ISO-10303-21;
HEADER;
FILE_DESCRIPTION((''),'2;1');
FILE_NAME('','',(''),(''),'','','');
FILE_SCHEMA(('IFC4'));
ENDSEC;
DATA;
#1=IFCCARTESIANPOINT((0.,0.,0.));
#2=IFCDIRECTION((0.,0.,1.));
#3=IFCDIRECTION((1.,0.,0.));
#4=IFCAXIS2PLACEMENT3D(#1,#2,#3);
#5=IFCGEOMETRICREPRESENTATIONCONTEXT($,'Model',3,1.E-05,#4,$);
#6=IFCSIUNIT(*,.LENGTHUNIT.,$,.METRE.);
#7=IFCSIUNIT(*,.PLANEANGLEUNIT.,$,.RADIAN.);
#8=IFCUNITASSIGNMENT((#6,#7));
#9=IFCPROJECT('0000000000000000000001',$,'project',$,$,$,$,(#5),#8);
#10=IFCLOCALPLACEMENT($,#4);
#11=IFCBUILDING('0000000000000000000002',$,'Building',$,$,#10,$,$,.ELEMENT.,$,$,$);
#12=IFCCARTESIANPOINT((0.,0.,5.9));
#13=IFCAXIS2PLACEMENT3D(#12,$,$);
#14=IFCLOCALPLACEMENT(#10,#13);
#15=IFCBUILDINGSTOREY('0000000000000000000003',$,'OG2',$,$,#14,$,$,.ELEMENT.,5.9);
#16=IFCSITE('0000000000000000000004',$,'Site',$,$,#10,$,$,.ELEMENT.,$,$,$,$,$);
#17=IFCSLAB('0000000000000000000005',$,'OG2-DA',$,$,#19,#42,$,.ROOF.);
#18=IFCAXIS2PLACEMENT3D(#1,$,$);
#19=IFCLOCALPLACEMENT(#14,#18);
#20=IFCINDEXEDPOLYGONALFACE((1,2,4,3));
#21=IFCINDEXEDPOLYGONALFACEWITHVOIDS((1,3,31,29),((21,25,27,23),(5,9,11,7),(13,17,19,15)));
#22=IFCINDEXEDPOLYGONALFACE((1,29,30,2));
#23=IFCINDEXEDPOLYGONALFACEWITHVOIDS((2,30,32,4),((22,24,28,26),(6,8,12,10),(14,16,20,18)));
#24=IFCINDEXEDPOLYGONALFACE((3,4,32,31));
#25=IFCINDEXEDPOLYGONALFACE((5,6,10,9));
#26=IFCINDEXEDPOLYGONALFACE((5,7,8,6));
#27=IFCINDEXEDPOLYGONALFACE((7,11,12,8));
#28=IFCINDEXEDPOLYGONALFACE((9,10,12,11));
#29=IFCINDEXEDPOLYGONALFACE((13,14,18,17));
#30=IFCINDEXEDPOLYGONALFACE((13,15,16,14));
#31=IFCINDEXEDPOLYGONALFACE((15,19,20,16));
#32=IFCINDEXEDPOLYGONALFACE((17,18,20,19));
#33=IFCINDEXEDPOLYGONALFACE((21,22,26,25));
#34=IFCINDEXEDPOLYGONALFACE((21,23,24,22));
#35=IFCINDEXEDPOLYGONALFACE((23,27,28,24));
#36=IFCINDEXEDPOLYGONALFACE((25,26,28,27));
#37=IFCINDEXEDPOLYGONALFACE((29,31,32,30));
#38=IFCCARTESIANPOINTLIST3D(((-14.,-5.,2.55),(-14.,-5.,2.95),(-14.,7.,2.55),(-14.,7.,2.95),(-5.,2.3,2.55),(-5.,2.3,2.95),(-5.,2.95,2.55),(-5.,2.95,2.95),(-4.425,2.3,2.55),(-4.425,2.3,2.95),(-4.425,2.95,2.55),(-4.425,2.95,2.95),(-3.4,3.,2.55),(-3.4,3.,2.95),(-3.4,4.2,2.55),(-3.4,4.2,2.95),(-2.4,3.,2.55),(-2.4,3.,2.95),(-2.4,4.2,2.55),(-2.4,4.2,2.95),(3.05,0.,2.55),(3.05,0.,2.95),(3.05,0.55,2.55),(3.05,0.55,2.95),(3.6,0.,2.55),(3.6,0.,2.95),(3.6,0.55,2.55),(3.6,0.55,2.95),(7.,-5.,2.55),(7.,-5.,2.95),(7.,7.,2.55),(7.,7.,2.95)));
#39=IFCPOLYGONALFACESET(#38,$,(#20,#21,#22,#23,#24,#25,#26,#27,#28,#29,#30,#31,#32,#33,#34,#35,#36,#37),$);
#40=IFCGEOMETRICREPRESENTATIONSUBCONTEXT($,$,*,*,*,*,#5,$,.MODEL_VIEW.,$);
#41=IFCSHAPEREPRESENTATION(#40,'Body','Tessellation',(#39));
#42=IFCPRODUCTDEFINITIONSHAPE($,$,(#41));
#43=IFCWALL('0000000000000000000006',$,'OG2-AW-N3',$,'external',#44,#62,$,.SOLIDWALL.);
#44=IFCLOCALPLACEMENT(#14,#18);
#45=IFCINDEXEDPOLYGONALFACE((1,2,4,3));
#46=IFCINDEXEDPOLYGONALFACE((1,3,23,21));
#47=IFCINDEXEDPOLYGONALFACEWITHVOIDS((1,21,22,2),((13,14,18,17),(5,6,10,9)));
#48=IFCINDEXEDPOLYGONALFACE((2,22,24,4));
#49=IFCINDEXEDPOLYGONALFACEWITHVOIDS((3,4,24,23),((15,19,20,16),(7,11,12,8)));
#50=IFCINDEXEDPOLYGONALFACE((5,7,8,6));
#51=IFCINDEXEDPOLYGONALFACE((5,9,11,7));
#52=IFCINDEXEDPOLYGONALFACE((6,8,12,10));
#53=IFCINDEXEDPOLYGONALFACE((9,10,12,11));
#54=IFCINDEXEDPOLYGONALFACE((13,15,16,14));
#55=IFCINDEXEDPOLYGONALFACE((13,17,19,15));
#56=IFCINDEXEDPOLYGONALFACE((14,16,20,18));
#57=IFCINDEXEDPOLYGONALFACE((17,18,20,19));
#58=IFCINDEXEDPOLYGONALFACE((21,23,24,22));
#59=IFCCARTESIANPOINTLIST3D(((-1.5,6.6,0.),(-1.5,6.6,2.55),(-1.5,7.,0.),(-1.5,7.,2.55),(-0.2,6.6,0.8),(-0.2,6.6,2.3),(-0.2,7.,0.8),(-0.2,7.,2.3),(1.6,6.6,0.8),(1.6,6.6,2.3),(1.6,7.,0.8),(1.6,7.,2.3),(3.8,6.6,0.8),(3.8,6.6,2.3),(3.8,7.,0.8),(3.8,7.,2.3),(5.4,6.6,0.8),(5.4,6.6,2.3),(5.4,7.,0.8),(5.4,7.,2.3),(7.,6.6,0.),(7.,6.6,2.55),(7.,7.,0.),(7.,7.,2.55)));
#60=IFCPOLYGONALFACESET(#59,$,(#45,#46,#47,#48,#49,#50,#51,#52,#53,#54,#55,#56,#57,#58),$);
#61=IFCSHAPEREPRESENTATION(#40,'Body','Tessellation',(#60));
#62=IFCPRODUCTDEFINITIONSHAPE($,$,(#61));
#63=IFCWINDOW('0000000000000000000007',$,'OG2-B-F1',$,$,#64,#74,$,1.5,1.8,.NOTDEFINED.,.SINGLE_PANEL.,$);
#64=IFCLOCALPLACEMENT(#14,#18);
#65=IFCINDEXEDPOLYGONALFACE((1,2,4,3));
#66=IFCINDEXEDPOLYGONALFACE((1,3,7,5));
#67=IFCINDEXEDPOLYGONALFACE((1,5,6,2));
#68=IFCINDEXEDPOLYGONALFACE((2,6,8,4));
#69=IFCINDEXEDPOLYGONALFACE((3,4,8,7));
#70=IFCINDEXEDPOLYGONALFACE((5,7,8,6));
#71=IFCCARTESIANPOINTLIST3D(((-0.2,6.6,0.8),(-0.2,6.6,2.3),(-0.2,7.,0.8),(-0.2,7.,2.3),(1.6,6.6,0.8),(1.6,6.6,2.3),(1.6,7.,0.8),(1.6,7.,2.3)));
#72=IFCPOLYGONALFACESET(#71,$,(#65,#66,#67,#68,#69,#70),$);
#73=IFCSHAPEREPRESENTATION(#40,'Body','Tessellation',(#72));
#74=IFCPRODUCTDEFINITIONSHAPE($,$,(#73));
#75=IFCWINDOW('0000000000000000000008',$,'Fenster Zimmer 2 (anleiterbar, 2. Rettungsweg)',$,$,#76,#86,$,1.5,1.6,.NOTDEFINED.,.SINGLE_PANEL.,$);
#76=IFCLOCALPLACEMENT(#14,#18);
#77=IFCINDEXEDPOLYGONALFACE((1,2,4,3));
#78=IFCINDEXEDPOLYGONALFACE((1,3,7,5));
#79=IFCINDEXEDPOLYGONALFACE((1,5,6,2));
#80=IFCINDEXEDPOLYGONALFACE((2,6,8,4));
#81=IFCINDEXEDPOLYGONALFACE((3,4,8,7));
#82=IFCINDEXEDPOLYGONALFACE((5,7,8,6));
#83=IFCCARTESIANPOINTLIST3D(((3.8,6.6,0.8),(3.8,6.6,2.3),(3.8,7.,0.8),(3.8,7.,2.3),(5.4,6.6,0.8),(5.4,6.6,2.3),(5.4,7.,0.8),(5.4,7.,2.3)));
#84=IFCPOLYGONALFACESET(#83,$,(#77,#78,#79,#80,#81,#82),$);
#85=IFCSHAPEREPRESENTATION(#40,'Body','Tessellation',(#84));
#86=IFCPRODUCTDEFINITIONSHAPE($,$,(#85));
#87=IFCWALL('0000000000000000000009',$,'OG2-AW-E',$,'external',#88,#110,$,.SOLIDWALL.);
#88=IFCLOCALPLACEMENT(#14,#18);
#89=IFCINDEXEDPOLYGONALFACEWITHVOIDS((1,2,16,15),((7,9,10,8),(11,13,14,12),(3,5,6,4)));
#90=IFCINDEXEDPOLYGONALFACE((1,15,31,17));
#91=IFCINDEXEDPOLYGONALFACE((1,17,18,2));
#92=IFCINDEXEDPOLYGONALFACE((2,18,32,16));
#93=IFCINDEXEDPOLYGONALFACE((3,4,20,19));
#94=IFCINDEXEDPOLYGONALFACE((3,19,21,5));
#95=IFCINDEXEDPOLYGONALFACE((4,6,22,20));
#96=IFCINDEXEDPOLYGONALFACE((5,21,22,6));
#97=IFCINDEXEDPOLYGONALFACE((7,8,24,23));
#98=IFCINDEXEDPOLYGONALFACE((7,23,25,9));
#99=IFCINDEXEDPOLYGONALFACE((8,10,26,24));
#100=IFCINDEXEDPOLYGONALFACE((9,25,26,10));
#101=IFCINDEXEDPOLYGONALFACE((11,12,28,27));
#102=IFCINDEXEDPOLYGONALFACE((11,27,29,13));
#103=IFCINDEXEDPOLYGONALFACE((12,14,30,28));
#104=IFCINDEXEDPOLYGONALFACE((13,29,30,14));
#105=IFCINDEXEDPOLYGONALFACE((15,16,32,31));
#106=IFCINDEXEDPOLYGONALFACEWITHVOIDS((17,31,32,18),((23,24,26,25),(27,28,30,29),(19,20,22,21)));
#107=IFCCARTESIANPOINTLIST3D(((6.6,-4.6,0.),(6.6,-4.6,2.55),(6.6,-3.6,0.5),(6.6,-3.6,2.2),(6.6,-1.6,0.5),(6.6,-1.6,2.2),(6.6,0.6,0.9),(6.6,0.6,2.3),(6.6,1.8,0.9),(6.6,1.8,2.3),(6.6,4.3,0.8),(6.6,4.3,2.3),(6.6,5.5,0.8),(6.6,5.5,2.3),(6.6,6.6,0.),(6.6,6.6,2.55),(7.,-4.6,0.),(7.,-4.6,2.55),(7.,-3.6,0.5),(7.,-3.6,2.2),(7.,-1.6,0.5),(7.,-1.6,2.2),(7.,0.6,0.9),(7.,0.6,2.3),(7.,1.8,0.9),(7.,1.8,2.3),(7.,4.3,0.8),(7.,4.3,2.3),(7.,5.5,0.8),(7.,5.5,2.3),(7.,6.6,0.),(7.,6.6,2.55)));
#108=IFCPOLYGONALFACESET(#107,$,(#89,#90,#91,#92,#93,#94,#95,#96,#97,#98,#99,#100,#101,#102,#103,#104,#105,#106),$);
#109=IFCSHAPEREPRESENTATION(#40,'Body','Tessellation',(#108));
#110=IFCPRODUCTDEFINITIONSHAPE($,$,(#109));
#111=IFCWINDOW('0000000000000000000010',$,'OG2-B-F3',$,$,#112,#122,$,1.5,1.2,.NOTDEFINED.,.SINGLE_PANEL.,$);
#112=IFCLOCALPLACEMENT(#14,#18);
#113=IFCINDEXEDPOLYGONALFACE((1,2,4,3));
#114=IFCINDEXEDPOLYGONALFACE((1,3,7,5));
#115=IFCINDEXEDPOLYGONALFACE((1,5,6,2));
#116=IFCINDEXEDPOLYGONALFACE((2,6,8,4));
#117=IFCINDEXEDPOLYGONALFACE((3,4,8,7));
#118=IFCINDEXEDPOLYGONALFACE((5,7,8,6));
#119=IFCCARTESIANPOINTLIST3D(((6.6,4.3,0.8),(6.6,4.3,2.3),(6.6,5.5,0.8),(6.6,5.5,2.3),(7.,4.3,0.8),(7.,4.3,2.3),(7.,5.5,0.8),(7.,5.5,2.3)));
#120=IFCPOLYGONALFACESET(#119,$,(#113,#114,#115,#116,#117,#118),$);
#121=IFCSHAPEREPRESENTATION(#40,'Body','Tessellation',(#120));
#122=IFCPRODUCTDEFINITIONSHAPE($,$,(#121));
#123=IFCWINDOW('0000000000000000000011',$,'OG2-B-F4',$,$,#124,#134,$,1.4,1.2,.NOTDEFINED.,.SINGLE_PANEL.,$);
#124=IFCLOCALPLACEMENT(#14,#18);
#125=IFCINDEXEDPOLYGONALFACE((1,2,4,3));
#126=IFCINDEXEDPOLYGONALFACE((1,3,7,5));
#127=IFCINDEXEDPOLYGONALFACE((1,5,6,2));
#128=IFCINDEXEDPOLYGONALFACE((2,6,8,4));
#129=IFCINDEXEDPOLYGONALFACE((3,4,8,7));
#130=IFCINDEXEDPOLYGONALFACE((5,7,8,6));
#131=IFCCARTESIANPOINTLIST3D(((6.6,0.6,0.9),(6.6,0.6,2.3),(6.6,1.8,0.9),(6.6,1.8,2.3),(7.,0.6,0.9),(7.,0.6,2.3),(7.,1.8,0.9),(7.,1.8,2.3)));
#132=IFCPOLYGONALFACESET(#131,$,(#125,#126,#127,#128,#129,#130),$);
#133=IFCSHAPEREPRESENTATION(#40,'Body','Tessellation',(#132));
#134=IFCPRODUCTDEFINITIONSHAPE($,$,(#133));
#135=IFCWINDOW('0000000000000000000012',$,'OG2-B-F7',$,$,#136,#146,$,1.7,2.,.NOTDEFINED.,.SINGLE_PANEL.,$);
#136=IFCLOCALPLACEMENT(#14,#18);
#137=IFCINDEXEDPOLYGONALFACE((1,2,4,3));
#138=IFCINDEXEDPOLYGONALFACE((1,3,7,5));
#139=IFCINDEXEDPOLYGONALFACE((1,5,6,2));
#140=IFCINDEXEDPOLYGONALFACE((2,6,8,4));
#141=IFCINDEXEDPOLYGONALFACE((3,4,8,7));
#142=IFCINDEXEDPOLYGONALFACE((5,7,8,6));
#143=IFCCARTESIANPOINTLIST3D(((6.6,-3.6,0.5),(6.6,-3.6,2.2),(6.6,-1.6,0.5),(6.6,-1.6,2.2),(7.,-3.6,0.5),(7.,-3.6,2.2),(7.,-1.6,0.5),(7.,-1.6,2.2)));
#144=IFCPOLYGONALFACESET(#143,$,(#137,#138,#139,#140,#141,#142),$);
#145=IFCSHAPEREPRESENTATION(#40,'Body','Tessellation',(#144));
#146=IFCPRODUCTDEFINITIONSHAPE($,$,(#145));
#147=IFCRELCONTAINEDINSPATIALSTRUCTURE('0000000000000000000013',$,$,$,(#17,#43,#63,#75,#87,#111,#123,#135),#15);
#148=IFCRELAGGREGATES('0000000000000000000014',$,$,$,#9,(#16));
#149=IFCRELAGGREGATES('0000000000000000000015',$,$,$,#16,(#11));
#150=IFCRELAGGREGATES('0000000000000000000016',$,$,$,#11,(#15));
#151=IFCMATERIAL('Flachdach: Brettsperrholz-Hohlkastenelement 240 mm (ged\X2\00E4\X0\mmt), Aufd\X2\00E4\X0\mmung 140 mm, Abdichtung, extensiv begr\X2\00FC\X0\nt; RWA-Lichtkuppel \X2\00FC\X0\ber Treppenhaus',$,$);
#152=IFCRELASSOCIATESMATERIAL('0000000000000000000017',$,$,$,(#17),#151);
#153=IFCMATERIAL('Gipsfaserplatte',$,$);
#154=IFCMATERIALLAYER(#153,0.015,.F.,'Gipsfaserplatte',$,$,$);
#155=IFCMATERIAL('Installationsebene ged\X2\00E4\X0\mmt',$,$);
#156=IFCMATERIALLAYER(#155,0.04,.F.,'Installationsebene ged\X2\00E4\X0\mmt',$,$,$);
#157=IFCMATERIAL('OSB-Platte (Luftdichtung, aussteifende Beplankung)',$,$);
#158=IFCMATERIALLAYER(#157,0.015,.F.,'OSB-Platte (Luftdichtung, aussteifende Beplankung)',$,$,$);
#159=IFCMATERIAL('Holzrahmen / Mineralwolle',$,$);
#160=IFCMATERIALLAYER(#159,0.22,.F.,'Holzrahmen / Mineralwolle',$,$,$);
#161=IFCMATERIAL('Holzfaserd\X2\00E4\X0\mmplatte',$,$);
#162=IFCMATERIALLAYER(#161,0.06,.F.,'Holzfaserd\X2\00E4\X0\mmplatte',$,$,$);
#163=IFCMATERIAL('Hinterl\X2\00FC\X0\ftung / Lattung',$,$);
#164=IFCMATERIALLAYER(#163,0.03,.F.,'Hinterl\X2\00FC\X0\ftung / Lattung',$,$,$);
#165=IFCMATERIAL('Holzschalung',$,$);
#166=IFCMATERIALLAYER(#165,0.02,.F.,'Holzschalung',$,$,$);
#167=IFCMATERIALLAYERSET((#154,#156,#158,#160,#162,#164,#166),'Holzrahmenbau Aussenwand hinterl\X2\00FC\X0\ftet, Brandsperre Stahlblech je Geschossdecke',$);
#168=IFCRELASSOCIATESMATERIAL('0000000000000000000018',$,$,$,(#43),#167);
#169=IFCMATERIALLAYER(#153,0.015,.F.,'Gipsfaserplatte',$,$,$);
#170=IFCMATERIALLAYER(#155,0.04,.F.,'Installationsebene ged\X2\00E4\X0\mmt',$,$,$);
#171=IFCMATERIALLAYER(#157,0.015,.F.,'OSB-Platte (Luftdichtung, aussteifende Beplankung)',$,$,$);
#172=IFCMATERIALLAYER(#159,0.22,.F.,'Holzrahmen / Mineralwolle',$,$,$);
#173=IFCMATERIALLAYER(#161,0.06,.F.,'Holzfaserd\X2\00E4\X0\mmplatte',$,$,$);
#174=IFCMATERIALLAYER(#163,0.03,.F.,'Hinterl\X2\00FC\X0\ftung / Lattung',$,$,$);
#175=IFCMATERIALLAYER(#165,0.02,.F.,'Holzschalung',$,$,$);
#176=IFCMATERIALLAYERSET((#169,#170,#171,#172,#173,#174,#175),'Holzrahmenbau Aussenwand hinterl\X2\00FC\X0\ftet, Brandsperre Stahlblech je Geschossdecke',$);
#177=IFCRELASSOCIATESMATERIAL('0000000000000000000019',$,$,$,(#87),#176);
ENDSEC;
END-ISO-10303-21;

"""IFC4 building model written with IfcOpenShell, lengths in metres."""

from ifc_helpers import new_model, si_unit, frame, frame_2d, origin, origin_with_axes, origin_2d, place, context, subcontext, project, spatial, polyline, rectangle, outline, extrude, material, layer, layer_set, element, fill, save


model = new_model("IFC4")

# Units and contexts
model_context = context("Model", 3, precision=1e-05, world=origin_with_axes())
sub_context = subcontext(model_context, None, None, "MODEL_VIEW")
ifc_project = project(units=[si_unit("LENGTHUNIT", "METRE"), si_unit("PLANEANGLEUNIT", "RADIAN")], contexts=[model_context])

# Site, building, storey
placement = place(None, origin_with_axes())
site = spatial("IfcSite", under=ifc_project, at=placement, Name="Site", CompositionType="ELEMENT")
building = spatial("IfcBuilding", under=site, at=placement, Name="Building", CompositionType="ELEMENT")
storey_placement = place(placement, frame((0.0, 0.0, 5.9)))
storey = spatial("IfcBuildingStorey", under=building, at=storey_placement, Name="OG2", CompositionType="ELEMENT", Elevation=5.9)

# Slab, openings
ifc_material_1 = material(Name="Flachdach: Brettsperrholz-Hohlkastenelement 240 mm (gedämmt), Aufdämmung 140 mm, Abdichtung, extensiv begrünt; RWA-Lichtkuppel über Treppenhaus")
slab_placement = place(storey_placement, frame((0.0, 0.0, 2.55)))
slab = element("IfcSlab", 1, at=slab_placement, inside=storey, material=ifc_material_1, Name="OG2-DA", PredefinedType="ROOF", context=sub_context, shape_type="SweptSolid", body=[
    extrude(outline(polyline([(-14.0, -5.0), (7.0, -5.0), (7.0, 7.0), (-14.0, 7.0), (-14.0, -5.0)])), origin(), (0.0, 0.0, 1.0), 0.4),
])
opening_1_placement = place(slab_placement, frame((-2.9, 3.6, 0.0)))
element("IfcOpeningElement", 2, at=opening_1_placement, cuts=slab, PredefinedType="OPENING", context=sub_context, shape_type="SweptSolid", body=[
    extrude(rectangle(XDim=1.0, YDim=1.2, at=origin_2d()), origin(), (0.0, 0.0, 1.0), 0.5),
])
opening_2_placement = place(slab_placement, frame((-4.7125, 2.625, 0.0)))
element("IfcOpeningElement", 3, at=opening_2_placement, cuts=slab, PredefinedType="OPENING", context=sub_context, shape_type="SweptSolid", body=[
    extrude(rectangle(XDim=0.575, YDim=0.65, at=origin_2d()), origin(), (0.0, 0.0, 1.0), 0.5),
])
opening_3_placement = place(slab_placement, frame((3.325, 0.275, 0.0)))
element("IfcOpeningElement", 4, at=opening_3_placement, cuts=slab, PredefinedType="OPENING", context=sub_context, shape_type="SweptSolid", body=[
    extrude(rectangle(XDim=0.55, YDim=0.55, at=origin_2d()), origin(), (0.0, 0.0, 1.0), 0.5),
])

# Walls, openings, windows
ifc_material_2 = material(Name="Gipsfaserplatte")
ifc_layer_1 = layer(ifc_material_2, 0.015, ventilated=False, Name="Gipsfaserplatte")
ifc_material_3 = material(Name="Installationsebene gedämmt")
ifc_layer_2 = layer(ifc_material_3, 0.04, ventilated=False, Name="Installationsebene gedämmt")
ifc_material_4 = material(Name="OSB-Platte (Luftdichtung, aussteifende Beplankung)")
ifc_layer_3 = layer(ifc_material_4, 0.015, ventilated=False, Name="OSB-Platte (Luftdichtung, aussteifende Beplankung)")
ifc_material_5 = material(Name="Holzrahmen / Mineralwolle")
ifc_layer_4 = layer(ifc_material_5, 0.22, ventilated=False, Name="Holzrahmen / Mineralwolle")
ifc_material_6 = material(Name="Holzfaserdämmplatte")
ifc_layer_5 = layer(ifc_material_6, 0.06, ventilated=False, Name="Holzfaserdämmplatte")
ifc_material_7 = material(Name="Hinterlüftung / Lattung")
ifc_layer_6 = layer(ifc_material_7, 0.03, ventilated=False, Name="Hinterlüftung / Lattung")
ifc_material_8 = material(Name="Holzschalung")
ifc_layer_7 = layer(ifc_material_8, 0.02, ventilated=False, Name="Holzschalung")
ifc_layer_set_1 = layer_set([ifc_layer_1, ifc_layer_2, ifc_layer_3, ifc_layer_4, ifc_layer_5, ifc_layer_6, ifc_layer_7], Name="Holzrahmenbau Aussenwand hinterlüftet, Brandsperre Stahlblech je Geschossdecke")
wall_1_placement = place(storey_placement, frame((-1.5, 6.8, 0.0), z_axis=(0.0, 0.0, 1.0), x_axis=(1.0, 0.0, 0.0)))
wall_1 = element("IfcWall", 5, at=wall_1_placement, inside=storey, material=ifc_layer_set_1, Name="OG2-AW-N3", ObjectType="external", PredefinedType="SOLIDWALL", context=sub_context, shape_type="SweptSolid", body=[
    extrude(rectangle(XDim=8.5, YDim=0.4, at=frame_2d((4.25, 0.0))), origin(), (0.0, 0.0, 1.0), 2.55),
])
opening_4_placement = place(wall_1_placement, frame((2.2, 0.25, 0.8), z_axis=(0.0, -1.0, 0.0), x_axis=(1.0, 0.0, 0.0)))
opening_4 = element("IfcOpeningElement", 6, at=opening_4_placement, cuts=wall_1, PredefinedType="OPENING", context=sub_context, shape_type="SweptSolid", body=[
    extrude(rectangle(XDim=1.8, YDim=1.5, at=frame_2d((0.0, 0.75))), origin(), (0.0, 0.0, 1.0), 0.5),
])
opening_5_placement = place(wall_1_placement, frame((6.1, 0.25, 0.8), z_axis=(0.0, -1.0, 0.0), x_axis=(1.0, 0.0, 0.0)))
opening_5 = element("IfcOpeningElement", 7, at=opening_5_placement, cuts=wall_1, PredefinedType="OPENING", context=sub_context, shape_type="SweptSolid", body=[
    extrude(rectangle(XDim=1.6, YDim=1.5, at=frame_2d((0.0, 0.75))), origin(), (0.0, 0.0, 1.0), 0.5),
])
window_1_placement = place(wall_1_placement, frame((2.2, 0.2, 0.8), z_axis=(0.0, -1.0, 0.0), x_axis=(1.0, 0.0, 0.0)))
window_1 = element("IfcWindow", 8, at=window_1_placement, inside=storey, Name="OG2-B-F1", OverallHeight=1.5, OverallWidth=1.8, PartitioningType="SINGLE_PANEL", PredefinedType="NOTDEFINED", context=sub_context, shape_type="SweptSolid", body=[
    extrude(rectangle(XDim=1.8, YDim=1.5, at=frame_2d((0.0, 0.75))), origin(), (0.0, 0.0, 1.0), 0.4),
])
fill(opening_4, window_1)
window_2_placement = place(wall_1_placement, frame((6.1, 0.2, 0.8), z_axis=(0.0, -1.0, 0.0), x_axis=(1.0, 0.0, 0.0)))
window_2 = element("IfcWindow", 9, at=window_2_placement, inside=storey, Name="Fenster Zimmer 2 (anleiterbar, 2. Rettungsweg)", OverallHeight=1.5, OverallWidth=1.6, PartitioningType="SINGLE_PANEL", PredefinedType="NOTDEFINED", context=sub_context, shape_type="SweptSolid", body=[
    extrude(rectangle(XDim=1.6, YDim=1.5, at=frame_2d((0.0, 0.75))), origin(), (0.0, 0.0, 1.0), 0.4),
])
fill(opening_5, window_2)
ifc_layer_8 = layer(ifc_material_2, 0.015, ventilated=False, Name="Gipsfaserplatte")
ifc_layer_9 = layer(ifc_material_3, 0.04, ventilated=False, Name="Installationsebene gedämmt")
ifc_layer_10 = layer(ifc_material_4, 0.015, ventilated=False, Name="OSB-Platte (Luftdichtung, aussteifende Beplankung)")
ifc_layer_11 = layer(ifc_material_5, 0.22, ventilated=False, Name="Holzrahmen / Mineralwolle")
ifc_layer_12 = layer(ifc_material_6, 0.06, ventilated=False, Name="Holzfaserdämmplatte")
ifc_layer_13 = layer(ifc_material_7, 0.03, ventilated=False, Name="Hinterlüftung / Lattung")
ifc_layer_14 = layer(ifc_material_8, 0.02, ventilated=False, Name="Holzschalung")
ifc_layer_set_2 = layer_set([ifc_layer_8, ifc_layer_9, ifc_layer_10, ifc_layer_11, ifc_layer_12, ifc_layer_13, ifc_layer_14], Name="Holzrahmenbau Aussenwand hinterlüftet, Brandsperre Stahlblech je Geschossdecke")
wall_2_placement = place(storey_placement, frame((6.8, 6.6, 0.0), z_axis=(0.0, 0.0, 1.0), x_axis=(0.0, -1.0, 0.0)))
wall_2 = element("IfcWall", 10, at=wall_2_placement, inside=storey, material=ifc_layer_set_2, Name="OG2-AW-E", ObjectType="external", PredefinedType="SOLIDWALL", context=sub_context, shape_type="SweptSolid", body=[
    extrude(rectangle(XDim=11.2, YDim=0.4, at=frame_2d((5.6, 0.0))), origin(), (0.0, 0.0, 1.0), 2.55),
])
opening_6_placement = place(wall_2_placement, frame((1.7, 0.25, 0.8), z_axis=(0.0, -1.0, 0.0), x_axis=(1.0, 0.0, 0.0)))
opening_6 = element("IfcOpeningElement", 11, at=opening_6_placement, cuts=wall_2, PredefinedType="OPENING", context=sub_context, shape_type="SweptSolid", body=[
    extrude(rectangle(XDim=1.2, YDim=1.5, at=frame_2d((0.0, 0.75))), origin(), (0.0, 0.0, 1.0), 0.5),
])
opening_7_placement = place(wall_2_placement, frame((5.4, 0.25, 0.9), z_axis=(0.0, -1.0, 0.0), x_axis=(1.0, 0.0, 0.0)))
opening_7 = element("IfcOpeningElement", 12, at=opening_7_placement, cuts=wall_2, PredefinedType="OPENING", context=sub_context, shape_type="SweptSolid", body=[
    extrude(rectangle(XDim=1.2, YDim=1.4, at=frame_2d((0.0, 0.7))), origin(), (0.0, 0.0, 1.0), 0.5),
])
opening_8_placement = place(wall_2_placement, frame((9.2, 0.25, 0.5), z_axis=(0.0, -1.0, 0.0), x_axis=(1.0, 0.0, 0.0)))
opening_8 = element("IfcOpeningElement", 13, at=opening_8_placement, cuts=wall_2, PredefinedType="OPENING", context=sub_context, shape_type="SweptSolid", body=[
    extrude(rectangle(XDim=2.0, YDim=1.7, at=frame_2d((0.0, 0.85))), origin(), (0.0, 0.0, 1.0), 0.5),
])
window_3_placement = place(wall_2_placement, frame((1.7, 0.2, 0.8), z_axis=(0.0, -1.0, 0.0), x_axis=(1.0, 0.0, 0.0)))
window_3 = element("IfcWindow", 14, at=window_3_placement, inside=storey, Name="OG2-B-F3", OverallHeight=1.5, OverallWidth=1.2, PartitioningType="SINGLE_PANEL", PredefinedType="NOTDEFINED", context=sub_context, shape_type="SweptSolid", body=[
    extrude(rectangle(XDim=1.2, YDim=1.5, at=frame_2d((0.0, 0.75))), origin(), (0.0, 0.0, 1.0), 0.4),
])
fill(opening_6, window_3)
window_4_placement = place(wall_2_placement, frame((5.4, 0.2, 0.9), z_axis=(0.0, -1.0, 0.0), x_axis=(1.0, 0.0, 0.0)))
window_4 = element("IfcWindow", 15, at=window_4_placement, inside=storey, Name="OG2-B-F4", OverallHeight=1.4, OverallWidth=1.2, PartitioningType="SINGLE_PANEL", PredefinedType="NOTDEFINED", context=sub_context, shape_type="SweptSolid", body=[
    extrude(rectangle(XDim=1.2, YDim=1.4, at=frame_2d((0.0, 0.7))), origin(), (0.0, 0.0, 1.0), 0.4),
])
fill(opening_7, window_4)
window_5_placement = place(wall_2_placement, frame((9.2, 0.2, 0.5), z_axis=(0.0, -1.0, 0.0), x_axis=(1.0, 0.0, 0.0)))
window_5 = element("IfcWindow", 16, at=window_5_placement, inside=storey, Name="OG2-B-F7", OverallHeight=1.7, OverallWidth=2.0, PartitioningType="SINGLE_PANEL", PredefinedType="NOTDEFINED", context=sub_context, shape_type="SweptSolid", body=[
    extrude(rectangle(XDim=2.0, YDim=1.7, at=frame_2d((0.0, 0.85))), origin(), (0.0, 0.0, 1.0), 0.4),
])
fill(opening_8, window_5)

save(model, "model.ifc")
